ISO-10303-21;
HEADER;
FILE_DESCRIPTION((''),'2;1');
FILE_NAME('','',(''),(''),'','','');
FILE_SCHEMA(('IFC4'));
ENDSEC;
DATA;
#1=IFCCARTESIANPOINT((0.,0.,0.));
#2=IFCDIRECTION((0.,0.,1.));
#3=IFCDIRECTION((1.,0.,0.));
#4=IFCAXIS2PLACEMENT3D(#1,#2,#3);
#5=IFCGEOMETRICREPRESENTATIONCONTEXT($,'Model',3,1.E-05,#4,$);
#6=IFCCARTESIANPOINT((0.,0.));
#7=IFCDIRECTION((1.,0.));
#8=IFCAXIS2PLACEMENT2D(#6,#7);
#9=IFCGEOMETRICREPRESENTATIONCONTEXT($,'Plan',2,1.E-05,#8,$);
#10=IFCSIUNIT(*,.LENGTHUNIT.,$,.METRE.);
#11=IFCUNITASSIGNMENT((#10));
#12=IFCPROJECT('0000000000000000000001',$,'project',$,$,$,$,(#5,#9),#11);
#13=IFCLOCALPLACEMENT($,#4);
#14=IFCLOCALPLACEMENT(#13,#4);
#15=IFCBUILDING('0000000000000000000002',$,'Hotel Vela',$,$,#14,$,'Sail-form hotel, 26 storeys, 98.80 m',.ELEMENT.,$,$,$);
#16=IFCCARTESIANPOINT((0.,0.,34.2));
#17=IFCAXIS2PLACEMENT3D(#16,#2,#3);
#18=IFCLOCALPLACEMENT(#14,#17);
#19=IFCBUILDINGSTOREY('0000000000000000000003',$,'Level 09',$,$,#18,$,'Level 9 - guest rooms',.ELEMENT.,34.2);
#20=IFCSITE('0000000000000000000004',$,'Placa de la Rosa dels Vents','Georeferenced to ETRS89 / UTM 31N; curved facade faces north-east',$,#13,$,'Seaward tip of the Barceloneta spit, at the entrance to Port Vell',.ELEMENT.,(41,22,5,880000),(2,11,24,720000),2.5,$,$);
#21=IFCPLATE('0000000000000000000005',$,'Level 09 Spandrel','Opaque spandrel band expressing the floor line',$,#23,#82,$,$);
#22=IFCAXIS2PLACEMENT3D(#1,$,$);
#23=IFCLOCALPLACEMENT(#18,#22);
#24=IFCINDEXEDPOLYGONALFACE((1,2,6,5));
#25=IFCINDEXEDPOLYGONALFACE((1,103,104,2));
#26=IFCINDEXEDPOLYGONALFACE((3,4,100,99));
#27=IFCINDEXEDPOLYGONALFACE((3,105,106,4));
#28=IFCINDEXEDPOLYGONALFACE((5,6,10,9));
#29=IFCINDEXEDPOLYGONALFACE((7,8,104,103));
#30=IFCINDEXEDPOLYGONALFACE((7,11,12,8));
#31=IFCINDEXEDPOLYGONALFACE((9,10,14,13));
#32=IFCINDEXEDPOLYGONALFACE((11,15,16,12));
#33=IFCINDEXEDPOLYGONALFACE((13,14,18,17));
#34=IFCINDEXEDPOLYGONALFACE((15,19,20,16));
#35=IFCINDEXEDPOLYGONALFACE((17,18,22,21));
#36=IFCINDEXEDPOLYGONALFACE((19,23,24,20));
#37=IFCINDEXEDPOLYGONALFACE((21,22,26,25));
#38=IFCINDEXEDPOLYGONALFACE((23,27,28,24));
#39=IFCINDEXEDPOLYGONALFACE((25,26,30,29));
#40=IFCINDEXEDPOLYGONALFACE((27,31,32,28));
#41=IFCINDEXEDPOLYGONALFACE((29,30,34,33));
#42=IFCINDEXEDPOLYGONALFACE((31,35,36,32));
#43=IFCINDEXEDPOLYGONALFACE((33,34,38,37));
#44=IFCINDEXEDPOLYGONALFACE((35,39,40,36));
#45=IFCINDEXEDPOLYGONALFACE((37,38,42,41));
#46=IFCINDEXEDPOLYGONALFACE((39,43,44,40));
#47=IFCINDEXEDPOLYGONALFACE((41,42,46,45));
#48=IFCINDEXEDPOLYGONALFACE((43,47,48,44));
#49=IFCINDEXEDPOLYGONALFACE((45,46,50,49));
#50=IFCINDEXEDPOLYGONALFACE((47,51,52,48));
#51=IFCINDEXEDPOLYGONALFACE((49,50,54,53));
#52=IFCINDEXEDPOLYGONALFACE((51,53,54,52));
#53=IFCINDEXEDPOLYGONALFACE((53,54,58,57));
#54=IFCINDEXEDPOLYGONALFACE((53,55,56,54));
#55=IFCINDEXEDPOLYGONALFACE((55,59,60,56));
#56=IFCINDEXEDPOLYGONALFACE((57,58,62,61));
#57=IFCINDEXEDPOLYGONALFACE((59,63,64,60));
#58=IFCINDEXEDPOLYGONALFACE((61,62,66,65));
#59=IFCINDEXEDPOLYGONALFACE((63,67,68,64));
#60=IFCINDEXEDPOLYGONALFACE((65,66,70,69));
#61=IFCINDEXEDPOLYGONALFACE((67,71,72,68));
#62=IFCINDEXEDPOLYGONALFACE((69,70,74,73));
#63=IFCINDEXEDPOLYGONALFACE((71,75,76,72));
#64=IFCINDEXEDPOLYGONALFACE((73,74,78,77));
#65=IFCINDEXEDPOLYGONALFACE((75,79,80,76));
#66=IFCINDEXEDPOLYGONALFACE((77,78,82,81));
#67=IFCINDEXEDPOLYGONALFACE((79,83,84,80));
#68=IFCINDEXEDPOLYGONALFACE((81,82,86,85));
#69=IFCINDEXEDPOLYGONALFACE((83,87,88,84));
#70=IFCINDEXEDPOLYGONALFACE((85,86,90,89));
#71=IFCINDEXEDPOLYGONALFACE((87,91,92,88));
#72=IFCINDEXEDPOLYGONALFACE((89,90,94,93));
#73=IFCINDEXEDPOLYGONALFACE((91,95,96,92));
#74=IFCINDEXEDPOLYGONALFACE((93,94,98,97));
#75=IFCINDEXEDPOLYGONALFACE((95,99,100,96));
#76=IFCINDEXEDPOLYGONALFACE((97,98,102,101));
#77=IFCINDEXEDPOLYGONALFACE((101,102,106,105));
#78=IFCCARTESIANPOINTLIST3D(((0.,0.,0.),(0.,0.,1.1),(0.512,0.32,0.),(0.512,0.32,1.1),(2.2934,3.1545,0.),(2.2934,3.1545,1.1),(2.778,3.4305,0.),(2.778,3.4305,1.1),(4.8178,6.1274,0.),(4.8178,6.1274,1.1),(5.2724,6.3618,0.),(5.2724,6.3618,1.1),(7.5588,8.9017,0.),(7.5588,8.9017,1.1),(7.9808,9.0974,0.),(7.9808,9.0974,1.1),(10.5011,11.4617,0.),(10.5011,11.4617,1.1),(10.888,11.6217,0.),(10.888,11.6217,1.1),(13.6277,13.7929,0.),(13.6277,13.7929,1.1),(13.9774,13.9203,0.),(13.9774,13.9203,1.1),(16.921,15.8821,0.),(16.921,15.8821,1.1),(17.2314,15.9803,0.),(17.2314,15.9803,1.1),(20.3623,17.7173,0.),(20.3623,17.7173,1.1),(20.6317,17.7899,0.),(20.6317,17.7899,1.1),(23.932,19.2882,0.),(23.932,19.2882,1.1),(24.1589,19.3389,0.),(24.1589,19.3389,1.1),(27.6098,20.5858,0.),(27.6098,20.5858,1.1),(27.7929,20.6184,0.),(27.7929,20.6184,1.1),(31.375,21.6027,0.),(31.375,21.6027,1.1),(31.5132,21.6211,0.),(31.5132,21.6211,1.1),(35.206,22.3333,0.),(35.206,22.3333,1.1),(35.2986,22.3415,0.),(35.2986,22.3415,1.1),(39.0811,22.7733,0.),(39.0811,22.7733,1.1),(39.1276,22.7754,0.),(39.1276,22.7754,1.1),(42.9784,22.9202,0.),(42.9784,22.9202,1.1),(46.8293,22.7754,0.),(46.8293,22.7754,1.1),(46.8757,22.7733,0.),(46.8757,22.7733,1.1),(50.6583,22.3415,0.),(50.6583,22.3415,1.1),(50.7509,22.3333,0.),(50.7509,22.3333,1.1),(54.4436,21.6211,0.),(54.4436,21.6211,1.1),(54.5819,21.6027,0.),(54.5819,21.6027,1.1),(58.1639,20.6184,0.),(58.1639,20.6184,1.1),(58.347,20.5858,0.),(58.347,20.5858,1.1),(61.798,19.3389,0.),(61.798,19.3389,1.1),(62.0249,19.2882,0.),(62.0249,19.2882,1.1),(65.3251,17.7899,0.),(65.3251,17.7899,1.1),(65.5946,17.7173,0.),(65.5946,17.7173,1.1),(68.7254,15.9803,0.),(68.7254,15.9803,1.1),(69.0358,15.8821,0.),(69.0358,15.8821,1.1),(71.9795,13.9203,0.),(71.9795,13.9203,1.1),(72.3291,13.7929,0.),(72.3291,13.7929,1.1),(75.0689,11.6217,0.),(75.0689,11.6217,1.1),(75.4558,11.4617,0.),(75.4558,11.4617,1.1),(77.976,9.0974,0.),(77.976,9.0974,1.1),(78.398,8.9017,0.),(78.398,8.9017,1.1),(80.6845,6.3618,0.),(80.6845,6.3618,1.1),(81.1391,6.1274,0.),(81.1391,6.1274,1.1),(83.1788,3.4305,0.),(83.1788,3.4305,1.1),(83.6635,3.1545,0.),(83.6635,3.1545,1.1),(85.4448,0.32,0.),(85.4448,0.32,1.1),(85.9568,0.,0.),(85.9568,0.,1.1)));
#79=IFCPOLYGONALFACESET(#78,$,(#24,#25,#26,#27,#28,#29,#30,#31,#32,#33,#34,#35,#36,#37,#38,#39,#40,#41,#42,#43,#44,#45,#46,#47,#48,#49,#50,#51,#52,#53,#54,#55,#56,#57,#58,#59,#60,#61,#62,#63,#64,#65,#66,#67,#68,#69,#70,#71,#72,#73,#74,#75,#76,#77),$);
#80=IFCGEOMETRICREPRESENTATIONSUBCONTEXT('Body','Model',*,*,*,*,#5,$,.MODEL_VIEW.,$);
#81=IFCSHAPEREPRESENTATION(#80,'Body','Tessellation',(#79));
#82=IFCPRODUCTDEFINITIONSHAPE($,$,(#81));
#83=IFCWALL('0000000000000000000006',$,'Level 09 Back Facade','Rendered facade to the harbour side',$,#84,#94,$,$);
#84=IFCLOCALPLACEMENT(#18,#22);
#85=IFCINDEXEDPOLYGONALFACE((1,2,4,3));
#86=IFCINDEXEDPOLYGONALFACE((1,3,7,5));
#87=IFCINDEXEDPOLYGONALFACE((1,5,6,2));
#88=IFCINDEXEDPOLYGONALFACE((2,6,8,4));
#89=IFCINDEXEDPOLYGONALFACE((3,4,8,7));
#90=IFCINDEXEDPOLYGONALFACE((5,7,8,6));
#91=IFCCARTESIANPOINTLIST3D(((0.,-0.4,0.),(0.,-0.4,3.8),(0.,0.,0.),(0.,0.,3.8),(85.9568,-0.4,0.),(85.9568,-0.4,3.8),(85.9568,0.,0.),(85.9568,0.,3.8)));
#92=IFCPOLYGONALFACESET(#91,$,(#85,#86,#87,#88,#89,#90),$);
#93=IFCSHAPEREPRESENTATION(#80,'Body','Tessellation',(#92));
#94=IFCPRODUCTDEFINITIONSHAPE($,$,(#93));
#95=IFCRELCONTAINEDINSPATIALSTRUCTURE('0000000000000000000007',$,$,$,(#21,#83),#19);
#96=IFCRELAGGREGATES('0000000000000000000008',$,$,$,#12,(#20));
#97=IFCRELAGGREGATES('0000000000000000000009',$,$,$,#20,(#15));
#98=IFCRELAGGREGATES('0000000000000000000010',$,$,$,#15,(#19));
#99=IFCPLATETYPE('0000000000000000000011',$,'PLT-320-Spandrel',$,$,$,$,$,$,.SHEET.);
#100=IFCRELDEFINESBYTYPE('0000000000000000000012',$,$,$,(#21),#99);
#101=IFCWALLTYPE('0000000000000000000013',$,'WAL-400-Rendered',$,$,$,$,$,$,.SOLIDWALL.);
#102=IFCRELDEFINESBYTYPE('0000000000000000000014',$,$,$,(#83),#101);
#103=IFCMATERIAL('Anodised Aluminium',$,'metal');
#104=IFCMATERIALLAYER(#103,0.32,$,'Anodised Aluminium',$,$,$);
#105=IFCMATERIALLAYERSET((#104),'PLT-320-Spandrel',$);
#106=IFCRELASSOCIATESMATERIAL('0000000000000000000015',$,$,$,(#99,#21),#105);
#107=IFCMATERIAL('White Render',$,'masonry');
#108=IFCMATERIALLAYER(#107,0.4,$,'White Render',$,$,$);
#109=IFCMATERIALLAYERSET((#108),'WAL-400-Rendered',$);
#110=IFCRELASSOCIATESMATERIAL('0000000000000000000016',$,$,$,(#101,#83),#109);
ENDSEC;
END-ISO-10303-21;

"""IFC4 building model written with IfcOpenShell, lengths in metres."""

from ifc_helpers import new_model, si_unit, frame, origin_with_axes, origin_2d_with_axis, place, context, subcontext, project, spatial, line, indexed_curve, outline, extrude, material, layer, layer_set, layer_usage, type_object, element, save


model = new_model("IFC4")

# Units and contexts
model_context = context("Model", 3, precision=1e-05, world=origin_with_axes())
plan_context = context("Plan", 2, precision=1e-05, world=origin_2d_with_axis())
body_context = subcontext(model_context, "Body", "Model", "MODEL_VIEW")
ifc_project = project(units=[si_unit("LENGTHUNIT", "METRE")], contexts=[model_context, plan_context])

# Site, building, storey
site_placement = place(None, origin_with_axes())
site = spatial("IfcSite", under=ifc_project, at=site_placement, Name="Placa de la Rosa dels Vents", Description="Georeferenced to ETRS89 / UTM 31N; curved facade faces north-east", LongName="Seaward tip of the Barceloneta spit, at the entrance to Port Vell", CompositionType="ELEMENT", RefLatitude=(41, 22, 5, 880000), RefLongitude=(2, 11, 24, 720000), RefElevation=2.5)
building_placement = place(site_placement, origin_with_axes())
building = spatial("IfcBuilding", under=site, at=building_placement, Name="Hotel Vela", LongName="Sail-form hotel, 26 storeys, 98.80 m", CompositionType="ELEMENT")
storey_placement = place(building_placement, frame((0.0, 0.0, 34.2), z_axis=(0.0, 0.0, 1.0), x_axis=(1.0, 0.0, 0.0)))
storey = spatial("IfcBuildingStorey", under=building, at=storey_placement, Name="Level 09", LongName="Level 9 - guest rooms", CompositionType="ELEMENT", Elevation=34.2)

# Plate
ifc_material_1 = material(Name="Anodised Aluminium", Category="metal")
ifc_layer_1 = layer(ifc_material_1, 0.32, Name="Anodised Aluminium")
ifc_layer_set_1 = layer_set([ifc_layer_1], Name="PLT-320-Spandrel")
ifc_layer_usage_1 = layer_usage(ifc_layer_set_1, "AXIS2", "POSITIVE", 0.0)
plate_type_1 = type_object("IfcPlateType", Name="PLT-320-Spandrel", PredefinedType="SHEET", material=ifc_layer_set_1)
plate_1_placement = place(storey_placement, origin_with_axes())
element("IfcPlate", 1, at=plate_1_placement, inside=storey, type_object=plate_type_1, material=ifc_layer_usage_1, Name="Level 09 Spandrel", Description="Opaque spandrel band expressing the floor line", context=body_context, shape_type="SweptSolid", body=[
    extrude(outline(indexed_curve([(85.9568, 0.0), (83.6635, 3.1545), (81.1391, 6.1274), (78.398, 8.9017), (75.4558, 11.4617), (72.3291, 13.7929), (69.0358, 15.8821), (65.5946, 17.7173), (62.0249, 19.2882), (58.347, 20.5858), (54.5819, 21.6027), (50.7509, 22.3333), (46.8757, 22.7733), (42.9784, 22.9202), (39.0811, 22.7733), (35.206, 22.3333), (31.375, 21.6027), (27.6098, 20.5858), (23.932, 19.2882), (20.3623, 17.7173), (16.921, 15.8821), (13.6277, 13.7929), (10.5011, 11.4617), (7.5588, 8.9017), (4.8178, 6.1274), (2.2934, 3.1545), (0.0, 0.0), (85.4448, 0.32), (2.778, 3.4305), (5.2724, 6.3618), (7.9808, 9.0974), (10.888, 11.6217), (13.9774, 13.9203), (17.2314, 15.9803), (20.6317, 17.7899), (24.1589, 19.3389), (27.7929, 20.6184), (31.5132, 21.6211), (35.2986, 22.3415), (39.1276, 22.7754), (42.9784, 22.9202), (46.8293, 22.7754), (50.6583, 22.3415), (54.4436, 21.6211), (58.1639, 20.6184), (61.798, 19.3389), (65.3251, 17.7899), (68.7254, 15.9803), (71.9795, 13.9203), (75.0689, 11.6217), (77.976, 9.0974), (80.6845, 6.3618), (83.1788, 3.4305), (0.512, 0.32)], segments=[line(1, 2, 3, 4, 5, 6, 7, 8, 9, 10, 11, 12, 13, 14, 15, 16, 17, 18, 19, 20, 21, 22, 23, 24, 25, 26, 27, 28, 29, 30, 31, 32, 33, 34, 35, 36, 37, 38, 39, 40, 41, 42, 43, 44, 45, 46, 47, 48, 49, 50, 51, 52, 53, 54, 1)])), origin_with_axes(), (0.0, 0.0, 1.0), 1.1),
])

# Wall
ifc_material_2 = material(Name="White Render", Category="masonry")
ifc_layer_2 = layer(ifc_material_2, 0.4, Name="White Render")
ifc_layer_set_2 = layer_set([ifc_layer_2], Name="WAL-400-Rendered")
ifc_layer_usage_2 = layer_usage(ifc_layer_set_2, "AXIS2", "POSITIVE", 0.0)
wall_type = type_object("IfcWallType", Name="WAL-400-Rendered", PredefinedType="SOLIDWALL", material=ifc_layer_set_2)
wall_placement = place(storey_placement, frame((0.0, -0.4, 0.0), z_axis=(0.0, 0.0, 1.0), x_axis=(1.0, 0.0, 0.0)))
element("IfcWall", 2, at=wall_placement, inside=storey, type_object=wall_type, material=ifc_layer_usage_2, Name="Level 09 Back Facade", Description="Rendered facade to the harbour side", context=body_context, shape_type="SweptSolid", body=[
    extrude(outline(indexed_curve([(0.0, 0.0), (85.9568, 0.0), (85.9568, 0.4), (0.0, 0.4)], segments=[line(1, 2, 3, 4, 1)])), origin_with_axes(), (0.0, 0.0, 1.0), 3.8),
])

save(model, "model.ifc")
